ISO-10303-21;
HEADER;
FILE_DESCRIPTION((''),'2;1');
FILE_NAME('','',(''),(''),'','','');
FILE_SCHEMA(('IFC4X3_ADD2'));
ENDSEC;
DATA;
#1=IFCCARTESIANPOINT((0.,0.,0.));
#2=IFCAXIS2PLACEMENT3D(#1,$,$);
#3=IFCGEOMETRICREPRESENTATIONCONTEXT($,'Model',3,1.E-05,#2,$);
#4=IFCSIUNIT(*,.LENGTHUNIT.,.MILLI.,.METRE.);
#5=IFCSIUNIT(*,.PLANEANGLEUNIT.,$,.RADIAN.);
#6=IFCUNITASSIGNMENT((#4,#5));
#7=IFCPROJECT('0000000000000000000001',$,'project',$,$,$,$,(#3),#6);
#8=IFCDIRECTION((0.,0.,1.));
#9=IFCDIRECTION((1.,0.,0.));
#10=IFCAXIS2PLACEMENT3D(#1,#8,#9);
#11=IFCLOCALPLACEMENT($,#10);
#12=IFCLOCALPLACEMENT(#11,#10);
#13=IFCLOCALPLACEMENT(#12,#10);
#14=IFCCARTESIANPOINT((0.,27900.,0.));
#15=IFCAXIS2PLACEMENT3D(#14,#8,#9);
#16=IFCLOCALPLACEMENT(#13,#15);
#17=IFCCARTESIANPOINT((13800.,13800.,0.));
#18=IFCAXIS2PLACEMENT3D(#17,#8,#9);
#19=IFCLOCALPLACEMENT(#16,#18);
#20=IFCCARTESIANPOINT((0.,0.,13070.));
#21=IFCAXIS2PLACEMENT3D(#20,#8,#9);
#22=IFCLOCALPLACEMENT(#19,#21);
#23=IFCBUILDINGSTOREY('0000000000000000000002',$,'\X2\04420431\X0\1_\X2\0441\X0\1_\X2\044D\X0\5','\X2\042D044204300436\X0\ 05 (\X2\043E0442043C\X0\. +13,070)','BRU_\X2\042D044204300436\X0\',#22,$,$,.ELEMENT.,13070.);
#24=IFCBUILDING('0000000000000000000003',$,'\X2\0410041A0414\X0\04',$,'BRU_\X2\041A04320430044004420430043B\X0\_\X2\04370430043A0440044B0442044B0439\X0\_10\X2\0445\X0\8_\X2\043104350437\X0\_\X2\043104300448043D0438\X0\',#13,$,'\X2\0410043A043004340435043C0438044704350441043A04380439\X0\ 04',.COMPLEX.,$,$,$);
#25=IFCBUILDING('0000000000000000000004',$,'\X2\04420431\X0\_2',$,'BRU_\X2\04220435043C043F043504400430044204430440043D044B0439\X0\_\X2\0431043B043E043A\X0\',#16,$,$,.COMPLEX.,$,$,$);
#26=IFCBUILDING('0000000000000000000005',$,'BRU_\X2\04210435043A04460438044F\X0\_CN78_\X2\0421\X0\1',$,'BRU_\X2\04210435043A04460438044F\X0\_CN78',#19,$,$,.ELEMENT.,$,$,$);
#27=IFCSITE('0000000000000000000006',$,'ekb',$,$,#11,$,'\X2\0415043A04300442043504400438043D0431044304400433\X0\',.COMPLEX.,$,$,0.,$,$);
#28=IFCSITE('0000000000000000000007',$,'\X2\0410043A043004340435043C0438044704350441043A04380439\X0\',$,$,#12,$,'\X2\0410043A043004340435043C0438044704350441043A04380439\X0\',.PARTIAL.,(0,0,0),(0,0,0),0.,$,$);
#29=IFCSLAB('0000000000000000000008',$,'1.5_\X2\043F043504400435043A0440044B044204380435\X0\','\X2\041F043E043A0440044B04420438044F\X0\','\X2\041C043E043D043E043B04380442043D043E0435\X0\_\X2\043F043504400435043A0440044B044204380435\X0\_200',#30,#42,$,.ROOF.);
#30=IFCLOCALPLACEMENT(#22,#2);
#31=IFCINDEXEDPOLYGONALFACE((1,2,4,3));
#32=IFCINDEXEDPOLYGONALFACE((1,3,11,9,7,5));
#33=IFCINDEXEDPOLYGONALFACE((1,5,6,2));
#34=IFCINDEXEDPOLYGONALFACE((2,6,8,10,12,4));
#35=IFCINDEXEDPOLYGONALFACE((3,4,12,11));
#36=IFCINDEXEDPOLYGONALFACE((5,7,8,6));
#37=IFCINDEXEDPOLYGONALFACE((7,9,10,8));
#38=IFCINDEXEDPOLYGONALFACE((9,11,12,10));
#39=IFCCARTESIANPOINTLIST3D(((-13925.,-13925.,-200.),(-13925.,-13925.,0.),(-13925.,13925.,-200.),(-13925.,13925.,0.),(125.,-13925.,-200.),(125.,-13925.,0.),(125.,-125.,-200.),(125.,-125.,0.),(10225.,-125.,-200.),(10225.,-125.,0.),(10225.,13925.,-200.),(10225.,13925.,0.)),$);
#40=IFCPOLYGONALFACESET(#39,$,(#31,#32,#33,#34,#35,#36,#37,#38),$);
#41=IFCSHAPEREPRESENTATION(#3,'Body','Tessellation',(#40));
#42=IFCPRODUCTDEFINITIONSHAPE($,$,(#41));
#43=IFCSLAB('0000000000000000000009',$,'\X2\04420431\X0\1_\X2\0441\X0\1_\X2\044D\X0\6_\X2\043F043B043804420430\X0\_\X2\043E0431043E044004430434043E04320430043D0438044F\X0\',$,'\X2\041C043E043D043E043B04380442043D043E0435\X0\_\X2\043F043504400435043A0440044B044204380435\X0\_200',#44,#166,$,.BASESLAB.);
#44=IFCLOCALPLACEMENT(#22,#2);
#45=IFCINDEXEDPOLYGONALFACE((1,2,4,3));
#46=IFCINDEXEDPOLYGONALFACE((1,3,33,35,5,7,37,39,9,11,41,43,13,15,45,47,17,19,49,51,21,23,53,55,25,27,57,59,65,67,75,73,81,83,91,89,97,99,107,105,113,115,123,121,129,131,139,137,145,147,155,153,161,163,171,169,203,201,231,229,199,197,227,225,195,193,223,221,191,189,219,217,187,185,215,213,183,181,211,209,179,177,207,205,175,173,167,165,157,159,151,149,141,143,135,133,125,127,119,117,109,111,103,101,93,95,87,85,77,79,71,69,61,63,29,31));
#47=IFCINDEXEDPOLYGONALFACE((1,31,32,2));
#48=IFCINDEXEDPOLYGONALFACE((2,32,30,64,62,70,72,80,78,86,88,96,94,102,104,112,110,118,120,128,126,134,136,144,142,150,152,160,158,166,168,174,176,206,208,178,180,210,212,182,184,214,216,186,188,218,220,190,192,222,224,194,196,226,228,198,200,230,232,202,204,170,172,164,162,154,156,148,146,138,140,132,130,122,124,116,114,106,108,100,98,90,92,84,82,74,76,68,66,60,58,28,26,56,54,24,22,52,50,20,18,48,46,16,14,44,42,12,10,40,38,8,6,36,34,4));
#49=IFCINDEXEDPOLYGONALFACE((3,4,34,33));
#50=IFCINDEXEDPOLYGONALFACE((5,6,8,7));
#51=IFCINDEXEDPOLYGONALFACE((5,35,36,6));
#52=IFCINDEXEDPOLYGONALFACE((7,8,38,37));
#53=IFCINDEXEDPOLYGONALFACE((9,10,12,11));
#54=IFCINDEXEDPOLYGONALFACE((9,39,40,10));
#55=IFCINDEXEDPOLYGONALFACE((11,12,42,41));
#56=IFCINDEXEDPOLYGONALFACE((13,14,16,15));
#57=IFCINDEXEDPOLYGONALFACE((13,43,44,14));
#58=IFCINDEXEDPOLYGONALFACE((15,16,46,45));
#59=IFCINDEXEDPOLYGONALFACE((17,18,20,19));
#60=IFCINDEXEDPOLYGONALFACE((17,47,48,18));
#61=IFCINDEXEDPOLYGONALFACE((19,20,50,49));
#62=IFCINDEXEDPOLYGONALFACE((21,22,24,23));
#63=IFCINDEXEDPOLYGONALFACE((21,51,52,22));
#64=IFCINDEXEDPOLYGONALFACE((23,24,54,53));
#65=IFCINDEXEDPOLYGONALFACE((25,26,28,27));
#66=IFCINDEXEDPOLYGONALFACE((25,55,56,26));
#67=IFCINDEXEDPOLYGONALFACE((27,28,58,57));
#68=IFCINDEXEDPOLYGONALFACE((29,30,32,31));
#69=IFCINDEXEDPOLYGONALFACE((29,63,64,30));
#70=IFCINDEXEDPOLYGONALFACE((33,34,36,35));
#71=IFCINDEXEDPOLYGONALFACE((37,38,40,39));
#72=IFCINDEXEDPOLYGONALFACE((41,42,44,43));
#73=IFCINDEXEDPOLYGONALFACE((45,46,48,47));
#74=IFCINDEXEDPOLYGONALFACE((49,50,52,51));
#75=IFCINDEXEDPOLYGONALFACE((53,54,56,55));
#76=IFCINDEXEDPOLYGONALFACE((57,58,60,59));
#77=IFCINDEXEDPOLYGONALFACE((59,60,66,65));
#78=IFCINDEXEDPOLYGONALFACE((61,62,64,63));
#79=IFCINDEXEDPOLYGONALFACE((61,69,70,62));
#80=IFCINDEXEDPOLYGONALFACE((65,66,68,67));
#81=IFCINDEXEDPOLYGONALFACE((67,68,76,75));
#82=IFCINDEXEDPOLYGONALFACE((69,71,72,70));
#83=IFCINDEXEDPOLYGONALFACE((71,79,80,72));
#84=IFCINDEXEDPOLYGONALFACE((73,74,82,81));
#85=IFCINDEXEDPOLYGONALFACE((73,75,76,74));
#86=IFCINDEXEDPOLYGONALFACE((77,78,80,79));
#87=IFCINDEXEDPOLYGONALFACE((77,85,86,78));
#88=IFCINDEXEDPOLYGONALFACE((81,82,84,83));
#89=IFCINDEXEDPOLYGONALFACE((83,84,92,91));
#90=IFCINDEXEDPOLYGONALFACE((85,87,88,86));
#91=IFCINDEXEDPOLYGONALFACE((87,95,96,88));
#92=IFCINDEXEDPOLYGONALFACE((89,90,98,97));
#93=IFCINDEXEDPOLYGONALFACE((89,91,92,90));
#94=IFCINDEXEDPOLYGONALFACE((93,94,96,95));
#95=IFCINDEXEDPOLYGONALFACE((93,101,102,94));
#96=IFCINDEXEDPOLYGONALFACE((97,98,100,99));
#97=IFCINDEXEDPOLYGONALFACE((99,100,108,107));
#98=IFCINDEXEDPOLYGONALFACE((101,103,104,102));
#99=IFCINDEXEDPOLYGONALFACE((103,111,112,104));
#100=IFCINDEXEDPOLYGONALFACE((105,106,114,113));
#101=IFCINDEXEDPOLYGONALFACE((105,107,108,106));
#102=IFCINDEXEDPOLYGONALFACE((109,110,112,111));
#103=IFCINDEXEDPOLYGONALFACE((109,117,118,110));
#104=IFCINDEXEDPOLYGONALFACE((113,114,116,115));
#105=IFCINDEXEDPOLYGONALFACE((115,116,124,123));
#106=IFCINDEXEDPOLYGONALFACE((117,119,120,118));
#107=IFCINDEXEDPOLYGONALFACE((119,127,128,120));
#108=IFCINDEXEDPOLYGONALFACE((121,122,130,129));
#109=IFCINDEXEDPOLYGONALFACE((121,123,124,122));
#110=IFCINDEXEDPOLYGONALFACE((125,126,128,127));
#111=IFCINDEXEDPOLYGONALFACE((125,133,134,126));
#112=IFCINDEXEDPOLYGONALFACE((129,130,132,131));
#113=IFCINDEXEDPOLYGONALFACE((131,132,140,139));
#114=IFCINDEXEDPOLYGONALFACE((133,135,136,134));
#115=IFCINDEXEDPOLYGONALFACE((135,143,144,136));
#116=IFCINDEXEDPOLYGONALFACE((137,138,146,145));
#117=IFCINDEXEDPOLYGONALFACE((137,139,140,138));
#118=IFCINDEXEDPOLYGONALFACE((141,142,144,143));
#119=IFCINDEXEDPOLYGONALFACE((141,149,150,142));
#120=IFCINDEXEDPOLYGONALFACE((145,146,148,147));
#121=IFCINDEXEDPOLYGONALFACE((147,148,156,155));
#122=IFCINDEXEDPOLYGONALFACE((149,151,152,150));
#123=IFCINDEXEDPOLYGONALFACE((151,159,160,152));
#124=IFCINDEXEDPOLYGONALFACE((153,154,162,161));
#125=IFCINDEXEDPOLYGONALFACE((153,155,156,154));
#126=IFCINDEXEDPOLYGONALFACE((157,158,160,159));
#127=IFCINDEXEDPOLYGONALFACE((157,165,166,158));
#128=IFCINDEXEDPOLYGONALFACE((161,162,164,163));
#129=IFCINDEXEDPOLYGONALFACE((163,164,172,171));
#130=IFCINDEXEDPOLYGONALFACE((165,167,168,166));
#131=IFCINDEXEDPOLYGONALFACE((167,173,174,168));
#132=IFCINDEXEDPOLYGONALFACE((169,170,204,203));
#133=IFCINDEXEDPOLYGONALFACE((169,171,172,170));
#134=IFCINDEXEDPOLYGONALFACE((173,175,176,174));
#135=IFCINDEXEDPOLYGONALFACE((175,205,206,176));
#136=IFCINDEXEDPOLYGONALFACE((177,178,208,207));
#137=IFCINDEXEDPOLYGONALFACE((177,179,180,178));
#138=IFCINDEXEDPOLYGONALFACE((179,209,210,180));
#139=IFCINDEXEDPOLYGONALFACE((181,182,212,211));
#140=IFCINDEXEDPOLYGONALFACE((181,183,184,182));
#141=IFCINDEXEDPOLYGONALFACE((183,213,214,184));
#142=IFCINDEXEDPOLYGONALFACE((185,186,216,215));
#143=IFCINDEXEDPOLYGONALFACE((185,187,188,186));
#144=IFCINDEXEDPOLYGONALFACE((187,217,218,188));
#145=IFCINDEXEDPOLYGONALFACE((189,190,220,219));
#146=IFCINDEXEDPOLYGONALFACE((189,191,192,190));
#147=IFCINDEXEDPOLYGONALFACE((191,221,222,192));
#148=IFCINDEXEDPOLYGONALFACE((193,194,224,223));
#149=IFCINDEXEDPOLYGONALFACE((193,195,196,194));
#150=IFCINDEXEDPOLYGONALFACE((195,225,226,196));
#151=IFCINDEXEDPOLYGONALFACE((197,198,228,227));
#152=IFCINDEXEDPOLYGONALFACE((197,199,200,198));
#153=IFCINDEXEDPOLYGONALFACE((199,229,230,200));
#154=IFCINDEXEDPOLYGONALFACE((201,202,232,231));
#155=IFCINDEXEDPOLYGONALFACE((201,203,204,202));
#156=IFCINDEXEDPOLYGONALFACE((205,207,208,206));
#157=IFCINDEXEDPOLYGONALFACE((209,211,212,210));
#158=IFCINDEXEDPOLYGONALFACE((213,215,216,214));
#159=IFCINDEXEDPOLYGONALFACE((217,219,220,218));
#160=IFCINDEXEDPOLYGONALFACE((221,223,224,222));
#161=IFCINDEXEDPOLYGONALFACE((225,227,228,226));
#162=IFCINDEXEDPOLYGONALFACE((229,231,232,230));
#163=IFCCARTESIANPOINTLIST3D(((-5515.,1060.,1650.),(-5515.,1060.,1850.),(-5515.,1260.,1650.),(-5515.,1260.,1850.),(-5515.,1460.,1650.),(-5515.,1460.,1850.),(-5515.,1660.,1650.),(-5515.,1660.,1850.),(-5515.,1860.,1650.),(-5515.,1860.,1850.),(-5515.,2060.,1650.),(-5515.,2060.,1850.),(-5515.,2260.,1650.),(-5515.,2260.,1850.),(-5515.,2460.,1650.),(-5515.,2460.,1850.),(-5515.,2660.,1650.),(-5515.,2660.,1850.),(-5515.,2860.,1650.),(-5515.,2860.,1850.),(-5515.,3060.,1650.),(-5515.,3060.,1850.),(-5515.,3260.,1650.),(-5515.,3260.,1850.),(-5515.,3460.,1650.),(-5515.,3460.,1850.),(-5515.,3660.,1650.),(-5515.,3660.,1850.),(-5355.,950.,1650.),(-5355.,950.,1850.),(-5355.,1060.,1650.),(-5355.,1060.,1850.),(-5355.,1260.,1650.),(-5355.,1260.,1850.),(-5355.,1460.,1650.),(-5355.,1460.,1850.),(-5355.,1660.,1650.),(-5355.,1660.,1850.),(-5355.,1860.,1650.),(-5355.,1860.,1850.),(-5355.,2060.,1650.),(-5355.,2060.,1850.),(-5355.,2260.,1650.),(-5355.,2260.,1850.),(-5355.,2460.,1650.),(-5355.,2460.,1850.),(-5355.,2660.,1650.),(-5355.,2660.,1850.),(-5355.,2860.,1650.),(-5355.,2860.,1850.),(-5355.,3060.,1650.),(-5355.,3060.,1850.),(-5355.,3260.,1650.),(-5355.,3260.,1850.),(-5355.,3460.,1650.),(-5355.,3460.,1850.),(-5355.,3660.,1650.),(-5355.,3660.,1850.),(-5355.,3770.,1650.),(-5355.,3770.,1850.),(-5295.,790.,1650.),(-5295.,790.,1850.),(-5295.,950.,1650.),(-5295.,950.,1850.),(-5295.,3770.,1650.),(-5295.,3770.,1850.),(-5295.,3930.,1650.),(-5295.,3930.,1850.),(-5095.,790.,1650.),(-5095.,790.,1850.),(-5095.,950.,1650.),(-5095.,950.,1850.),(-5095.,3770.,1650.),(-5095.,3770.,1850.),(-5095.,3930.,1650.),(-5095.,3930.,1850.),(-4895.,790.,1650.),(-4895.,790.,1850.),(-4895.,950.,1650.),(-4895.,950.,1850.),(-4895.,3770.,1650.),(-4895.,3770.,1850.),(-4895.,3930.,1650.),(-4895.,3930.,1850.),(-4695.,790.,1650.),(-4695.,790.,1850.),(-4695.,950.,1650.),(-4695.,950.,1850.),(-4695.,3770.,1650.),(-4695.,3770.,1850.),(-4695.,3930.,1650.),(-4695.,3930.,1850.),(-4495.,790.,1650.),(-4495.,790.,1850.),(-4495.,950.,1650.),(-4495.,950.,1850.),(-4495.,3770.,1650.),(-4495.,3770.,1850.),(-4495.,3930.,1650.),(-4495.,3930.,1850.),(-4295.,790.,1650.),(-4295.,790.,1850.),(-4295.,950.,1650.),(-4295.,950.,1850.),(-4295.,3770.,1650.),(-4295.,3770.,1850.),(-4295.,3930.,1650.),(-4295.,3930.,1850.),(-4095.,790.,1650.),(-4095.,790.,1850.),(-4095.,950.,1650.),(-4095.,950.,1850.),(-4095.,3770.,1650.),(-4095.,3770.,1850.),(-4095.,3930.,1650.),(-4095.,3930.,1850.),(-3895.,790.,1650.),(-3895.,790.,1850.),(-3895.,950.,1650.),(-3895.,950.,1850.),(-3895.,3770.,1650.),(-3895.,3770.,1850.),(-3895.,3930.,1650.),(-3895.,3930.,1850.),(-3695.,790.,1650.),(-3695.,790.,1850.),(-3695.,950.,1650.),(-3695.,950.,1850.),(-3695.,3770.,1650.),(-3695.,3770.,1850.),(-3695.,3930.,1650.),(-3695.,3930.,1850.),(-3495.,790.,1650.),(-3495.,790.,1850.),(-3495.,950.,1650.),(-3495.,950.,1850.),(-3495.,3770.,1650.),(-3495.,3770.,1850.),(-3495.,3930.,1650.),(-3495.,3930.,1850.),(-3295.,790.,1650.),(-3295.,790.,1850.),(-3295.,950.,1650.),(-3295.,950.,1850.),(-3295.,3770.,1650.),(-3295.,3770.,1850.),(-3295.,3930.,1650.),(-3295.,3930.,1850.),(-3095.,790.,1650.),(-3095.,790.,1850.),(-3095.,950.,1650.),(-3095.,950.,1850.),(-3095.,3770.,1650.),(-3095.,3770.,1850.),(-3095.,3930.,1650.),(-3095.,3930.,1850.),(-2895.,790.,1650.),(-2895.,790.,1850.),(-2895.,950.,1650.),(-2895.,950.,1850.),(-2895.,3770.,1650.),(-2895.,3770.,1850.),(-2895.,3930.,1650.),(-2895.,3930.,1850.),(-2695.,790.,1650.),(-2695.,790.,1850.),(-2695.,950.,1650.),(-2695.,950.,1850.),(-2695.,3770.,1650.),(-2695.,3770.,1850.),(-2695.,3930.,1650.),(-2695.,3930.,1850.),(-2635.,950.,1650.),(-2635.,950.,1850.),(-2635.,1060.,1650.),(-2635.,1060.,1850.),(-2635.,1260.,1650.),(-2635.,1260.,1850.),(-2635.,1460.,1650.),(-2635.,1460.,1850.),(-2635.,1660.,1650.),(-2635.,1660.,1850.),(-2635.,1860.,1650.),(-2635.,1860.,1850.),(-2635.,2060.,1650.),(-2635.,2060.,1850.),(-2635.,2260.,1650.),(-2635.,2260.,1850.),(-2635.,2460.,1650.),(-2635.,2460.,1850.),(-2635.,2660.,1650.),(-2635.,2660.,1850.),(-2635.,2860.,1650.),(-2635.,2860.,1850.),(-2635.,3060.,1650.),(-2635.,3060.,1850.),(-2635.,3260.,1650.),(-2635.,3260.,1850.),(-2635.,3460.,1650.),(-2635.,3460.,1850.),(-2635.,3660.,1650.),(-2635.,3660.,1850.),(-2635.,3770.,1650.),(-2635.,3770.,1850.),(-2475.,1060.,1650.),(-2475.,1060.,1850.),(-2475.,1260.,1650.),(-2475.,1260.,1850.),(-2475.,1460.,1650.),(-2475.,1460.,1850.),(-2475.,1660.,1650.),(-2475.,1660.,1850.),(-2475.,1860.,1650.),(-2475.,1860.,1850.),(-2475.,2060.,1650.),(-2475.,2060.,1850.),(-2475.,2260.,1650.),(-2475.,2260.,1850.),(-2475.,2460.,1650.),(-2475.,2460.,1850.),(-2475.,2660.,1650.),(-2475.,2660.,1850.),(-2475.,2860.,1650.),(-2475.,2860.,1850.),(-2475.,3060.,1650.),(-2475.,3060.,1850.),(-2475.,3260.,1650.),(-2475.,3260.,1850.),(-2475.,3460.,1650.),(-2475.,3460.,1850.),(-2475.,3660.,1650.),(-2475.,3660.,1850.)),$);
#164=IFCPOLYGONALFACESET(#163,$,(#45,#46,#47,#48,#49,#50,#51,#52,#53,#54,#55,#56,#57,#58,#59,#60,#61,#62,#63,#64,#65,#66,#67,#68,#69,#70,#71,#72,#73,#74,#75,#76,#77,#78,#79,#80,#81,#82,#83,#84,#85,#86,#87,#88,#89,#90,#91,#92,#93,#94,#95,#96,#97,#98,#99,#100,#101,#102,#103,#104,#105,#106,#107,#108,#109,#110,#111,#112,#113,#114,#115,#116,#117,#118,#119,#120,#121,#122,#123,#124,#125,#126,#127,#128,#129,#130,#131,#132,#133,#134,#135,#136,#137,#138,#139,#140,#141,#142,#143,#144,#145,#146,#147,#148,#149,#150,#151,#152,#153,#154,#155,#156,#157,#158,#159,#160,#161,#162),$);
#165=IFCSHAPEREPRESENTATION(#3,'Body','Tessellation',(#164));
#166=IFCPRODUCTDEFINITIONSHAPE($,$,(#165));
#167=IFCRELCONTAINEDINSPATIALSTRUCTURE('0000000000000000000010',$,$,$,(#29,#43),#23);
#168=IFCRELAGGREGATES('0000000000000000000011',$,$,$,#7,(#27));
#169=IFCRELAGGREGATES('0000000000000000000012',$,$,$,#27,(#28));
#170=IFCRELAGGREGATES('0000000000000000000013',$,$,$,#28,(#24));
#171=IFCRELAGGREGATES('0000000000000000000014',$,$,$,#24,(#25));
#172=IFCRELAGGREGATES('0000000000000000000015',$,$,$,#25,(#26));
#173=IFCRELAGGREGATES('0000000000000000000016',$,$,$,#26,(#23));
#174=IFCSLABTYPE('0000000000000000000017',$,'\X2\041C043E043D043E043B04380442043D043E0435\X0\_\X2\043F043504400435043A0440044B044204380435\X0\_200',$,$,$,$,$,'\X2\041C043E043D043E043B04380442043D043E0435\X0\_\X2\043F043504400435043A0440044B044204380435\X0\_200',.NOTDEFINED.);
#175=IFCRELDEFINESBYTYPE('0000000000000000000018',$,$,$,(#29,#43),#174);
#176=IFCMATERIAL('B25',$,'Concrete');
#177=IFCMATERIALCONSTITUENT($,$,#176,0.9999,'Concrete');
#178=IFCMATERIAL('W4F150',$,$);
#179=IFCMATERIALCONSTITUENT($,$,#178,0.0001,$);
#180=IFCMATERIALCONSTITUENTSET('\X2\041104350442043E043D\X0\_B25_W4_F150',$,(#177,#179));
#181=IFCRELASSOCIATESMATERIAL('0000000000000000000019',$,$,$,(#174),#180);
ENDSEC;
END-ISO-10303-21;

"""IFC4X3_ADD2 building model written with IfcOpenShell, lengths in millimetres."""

from ifc_helpers import new_model, si_unit, frame, origin, origin_with_axes, place, context, project, spatial, polyline, outline, extrude, material, constituent, constituent_set, type_object, element, save


model = new_model("IFC4X3_ADD2")

# Units and contexts
model_context = context("Model", 3, precision=1e-05, world=origin())
ifc_project = project(units=[si_unit("LENGTHUNIT", "METRE", prefix="MILLI"), si_unit("PLANEANGLEUNIT", "RADIAN")], contexts=[model_context])

# Sites, buildings, storey
site_1_placement = place(None, origin_with_axes())
site_1 = spatial("IfcSite", under=ifc_project, at=site_1_placement, Name="ekb", LongName="Екатеринбург", CompositionType="COMPLEX", RefElevation=0.0)
site_2_placement = place(site_1_placement, origin_with_axes())
site_2 = spatial("IfcSite", under=site_1, at=site_2_placement, Name="Академический", LongName="Академический", CompositionType="PARTIAL", RefLatitude=(0, 0, 0), RefLongitude=(0, 0, 0), RefElevation=0.0)
building_1_placement = place(site_2_placement, origin_with_axes())
building_1 = spatial("IfcBuilding", under=site_2, at=building_1_placement, Name="АКД04", ObjectType="BRU_Квартал_закрытый_10х8_без_башни", LongName="Академический 04", CompositionType="COMPLEX")
building_2_placement = place(building_1_placement, frame((0.0, 27900.0, 0.0), z_axis=(0.0, 0.0, 1.0), x_axis=(1.0, 0.0, 0.0)))
building_2 = spatial("IfcBuilding", under=building_1, at=building_2_placement, Name="тб_2", ObjectType="BRU_Температурный_блок", CompositionType="COMPLEX")
building_3_placement = place(building_2_placement, frame((13800.0, 13800.0, 0.0), z_axis=(0.0, 0.0, 1.0), x_axis=(1.0, 0.0, 0.0)))
building_3 = spatial("IfcBuilding", under=building_2, at=building_3_placement, Name="BRU_Секция_CN78_С1", ObjectType="BRU_Секция_CN78", CompositionType="ELEMENT")
storey_placement = place(building_3_placement, frame((0.0, 0.0, 13070.0), z_axis=(0.0, 0.0, 1.0), x_axis=(1.0, 0.0, 0.0)))
storey = spatial("IfcBuildingStorey", under=building_3, at=storey_placement, Name="тб1_с1_э5", Description="Этаж 05 (отм. +13,070)", ObjectType="BRU_Этаж", CompositionType="ELEMENT", Elevation=13070.0)

# Shared definitions
ifc_material_1 = material(Name="B25", Category="Concrete")
ifc_material_2 = material(Name="W4F150")

# Slabs
ifc_constituent_1 = constituent(ifc_material_1, Category="Concrete", fraction=0.9999)
ifc_constituent_2 = constituent(ifc_material_2, fraction=0.0001)
ifc_constituent_set_1 = constituent_set(constituents=[ifc_constituent_1, ifc_constituent_2], Name="Бетон_B25_W4_F150")
slab_type = type_object("IfcSlabType", Name="Монолитное_перекрытие_200", ElementType="Монолитное_перекрытие_200", PredefinedType="NOTDEFINED", material=ifc_constituent_set_1)
slab_1_placement = place(storey_placement, frame((0.0, 0.0, -200.0), z_axis=(0.0, 0.0, 1.0), x_axis=(1.0, 0.0, 0.0)))
element("IfcSlab", 1, at=slab_1_placement, inside=storey, type_object=slab_type, Name="1.5_перекрытие", Description="Покрытия", ObjectType="Монолитное_перекрытие_200", PredefinedType="ROOF", context=model_context, shape_type="SweptSolid", body=[
    extrude(outline(polyline([(-13925.0, -13925.0), (125.0, -13925.0), (125.0, -125.0), (10225.0, -125.0), (10225.0, 13925.0), (-13925.0, 13925.0), (-13925.0, -13925.0)])), origin_with_axes(), (0.0, 0.0, 1.0), 200.0),
])
slab_2_placement = place(storey_placement, frame((0.0, 0.0, 1650.0), z_axis=(0.0, 0.0, 1.0), x_axis=(1.0, 0.0, 0.0)))
element("IfcSlab", 2, at=slab_2_placement, inside=storey, type_object=slab_type, Name="тб1_с1_э6_плита_оборудования", ObjectType="Монолитное_перекрытие_200", PredefinedType="BASESLAB", context=model_context, shape_type="SweptSolid", body=[
    extrude(outline(polyline([(-5295.0, 790.0), (-5295.0, 950.0), (-5355.0, 950.0), (-5355.0, 1060.0), (-5515.0, 1060.0), (-5515.0, 1260.0), (-5355.0, 1260.0), (-5355.0, 1460.0), (-5515.0, 1460.0), (-5515.0, 1660.0), (-5355.0, 1660.0), (-5355.0, 1860.0), (-5515.0, 1860.0), (-5515.0, 2060.0), (-5355.0, 2060.0), (-5355.0, 2260.0), (-5515.0, 2260.0), (-5515.0, 2460.0), (-5355.0, 2460.0), (-5355.0, 2660.0), (-5515.0, 2660.0), (-5515.0, 2860.0), (-5355.0, 2860.0), (-5355.0, 3060.0), (-5515.0, 3060.0), (-5515.0, 3260.0), (-5355.0, 3260.0), (-5355.0, 3460.0), (-5515.0, 3460.0), (-5515.0, 3660.0), (-5355.0, 3660.0), (-5355.0, 3770.0), (-5295.0, 3770.0), (-5295.0, 3930.0), (-5095.0, 3930.0), (-5095.0, 3770.0), (-4895.0, 3770.0), (-4895.0, 3930.0), (-4695.0, 3930.0), (-4695.0, 3770.0), (-4495.0, 3770.0), (-4495.0, 3930.0), (-4295.0, 3930.0), (-4295.0, 3770.0), (-4095.0, 3770.0), (-4095.0, 3930.0), (-3895.0, 3930.0), (-3895.0, 3770.0), (-3695.0, 3770.0), (-3695.0, 3930.0), (-3495.0, 3930.0), (-3495.0, 3770.0), (-3295.0, 3770.0), (-3295.0, 3930.0), (-3095.0, 3930.0), (-3095.0, 3770.0), (-2895.0, 3770.0), (-2895.0, 3930.0), (-2695.0, 3930.0), (-2695.0, 3770.0), (-2635.0, 3770.0), (-2635.0, 3660.0), (-2475.0, 3660.0), (-2475.0, 3460.0), (-2635.0, 3460.0), (-2635.0, 3260.0), (-2475.0, 3260.0), (-2475.0, 3060.0), (-2635.0, 3060.0), (-2635.0, 2860.0), (-2475.0, 2860.0), (-2475.0, 2660.0), (-2635.0, 2660.0), (-2635.0, 2460.0), (-2475.0, 2460.0), (-2475.0, 2260.0), (-2635.0, 2260.0), (-2635.0, 2060.0), (-2475.0, 2060.0), (-2475.0, 1860.0), (-2635.0, 1860.0), (-2635.0, 1660.0), (-2475.0, 1660.0), (-2475.0, 1460.0), (-2635.0, 1460.0), (-2635.0, 1260.0), (-2475.0, 1260.0), (-2475.0, 1060.0), (-2635.0, 1060.0), (-2635.0, 950.0), (-2695.0, 950.0), (-2695.0, 790.0), (-2895.0, 790.0), (-2895.0, 950.0), (-3095.0, 950.0), (-3095.0, 790.0), (-3295.0, 790.0), (-3295.0, 950.0), (-3495.0, 950.0), (-3495.0, 790.0), (-3695.0, 790.0), (-3695.0, 950.0), (-3895.0, 950.0), (-3895.0, 790.0), (-4095.0, 790.0), (-4095.0, 950.0), (-4295.0, 950.0), (-4295.0, 790.0), (-4495.0, 790.0), (-4495.0, 950.0), (-4695.0, 950.0), (-4695.0, 790.0), (-4895.0, 790.0), (-4895.0, 950.0), (-5095.0, 950.0), (-5095.0, 790.0), (-5295.0, 790.0)])), origin_with_axes(), (0.0, 0.0, 1.0), 200.0),
])

save(model, "model.ifc")
